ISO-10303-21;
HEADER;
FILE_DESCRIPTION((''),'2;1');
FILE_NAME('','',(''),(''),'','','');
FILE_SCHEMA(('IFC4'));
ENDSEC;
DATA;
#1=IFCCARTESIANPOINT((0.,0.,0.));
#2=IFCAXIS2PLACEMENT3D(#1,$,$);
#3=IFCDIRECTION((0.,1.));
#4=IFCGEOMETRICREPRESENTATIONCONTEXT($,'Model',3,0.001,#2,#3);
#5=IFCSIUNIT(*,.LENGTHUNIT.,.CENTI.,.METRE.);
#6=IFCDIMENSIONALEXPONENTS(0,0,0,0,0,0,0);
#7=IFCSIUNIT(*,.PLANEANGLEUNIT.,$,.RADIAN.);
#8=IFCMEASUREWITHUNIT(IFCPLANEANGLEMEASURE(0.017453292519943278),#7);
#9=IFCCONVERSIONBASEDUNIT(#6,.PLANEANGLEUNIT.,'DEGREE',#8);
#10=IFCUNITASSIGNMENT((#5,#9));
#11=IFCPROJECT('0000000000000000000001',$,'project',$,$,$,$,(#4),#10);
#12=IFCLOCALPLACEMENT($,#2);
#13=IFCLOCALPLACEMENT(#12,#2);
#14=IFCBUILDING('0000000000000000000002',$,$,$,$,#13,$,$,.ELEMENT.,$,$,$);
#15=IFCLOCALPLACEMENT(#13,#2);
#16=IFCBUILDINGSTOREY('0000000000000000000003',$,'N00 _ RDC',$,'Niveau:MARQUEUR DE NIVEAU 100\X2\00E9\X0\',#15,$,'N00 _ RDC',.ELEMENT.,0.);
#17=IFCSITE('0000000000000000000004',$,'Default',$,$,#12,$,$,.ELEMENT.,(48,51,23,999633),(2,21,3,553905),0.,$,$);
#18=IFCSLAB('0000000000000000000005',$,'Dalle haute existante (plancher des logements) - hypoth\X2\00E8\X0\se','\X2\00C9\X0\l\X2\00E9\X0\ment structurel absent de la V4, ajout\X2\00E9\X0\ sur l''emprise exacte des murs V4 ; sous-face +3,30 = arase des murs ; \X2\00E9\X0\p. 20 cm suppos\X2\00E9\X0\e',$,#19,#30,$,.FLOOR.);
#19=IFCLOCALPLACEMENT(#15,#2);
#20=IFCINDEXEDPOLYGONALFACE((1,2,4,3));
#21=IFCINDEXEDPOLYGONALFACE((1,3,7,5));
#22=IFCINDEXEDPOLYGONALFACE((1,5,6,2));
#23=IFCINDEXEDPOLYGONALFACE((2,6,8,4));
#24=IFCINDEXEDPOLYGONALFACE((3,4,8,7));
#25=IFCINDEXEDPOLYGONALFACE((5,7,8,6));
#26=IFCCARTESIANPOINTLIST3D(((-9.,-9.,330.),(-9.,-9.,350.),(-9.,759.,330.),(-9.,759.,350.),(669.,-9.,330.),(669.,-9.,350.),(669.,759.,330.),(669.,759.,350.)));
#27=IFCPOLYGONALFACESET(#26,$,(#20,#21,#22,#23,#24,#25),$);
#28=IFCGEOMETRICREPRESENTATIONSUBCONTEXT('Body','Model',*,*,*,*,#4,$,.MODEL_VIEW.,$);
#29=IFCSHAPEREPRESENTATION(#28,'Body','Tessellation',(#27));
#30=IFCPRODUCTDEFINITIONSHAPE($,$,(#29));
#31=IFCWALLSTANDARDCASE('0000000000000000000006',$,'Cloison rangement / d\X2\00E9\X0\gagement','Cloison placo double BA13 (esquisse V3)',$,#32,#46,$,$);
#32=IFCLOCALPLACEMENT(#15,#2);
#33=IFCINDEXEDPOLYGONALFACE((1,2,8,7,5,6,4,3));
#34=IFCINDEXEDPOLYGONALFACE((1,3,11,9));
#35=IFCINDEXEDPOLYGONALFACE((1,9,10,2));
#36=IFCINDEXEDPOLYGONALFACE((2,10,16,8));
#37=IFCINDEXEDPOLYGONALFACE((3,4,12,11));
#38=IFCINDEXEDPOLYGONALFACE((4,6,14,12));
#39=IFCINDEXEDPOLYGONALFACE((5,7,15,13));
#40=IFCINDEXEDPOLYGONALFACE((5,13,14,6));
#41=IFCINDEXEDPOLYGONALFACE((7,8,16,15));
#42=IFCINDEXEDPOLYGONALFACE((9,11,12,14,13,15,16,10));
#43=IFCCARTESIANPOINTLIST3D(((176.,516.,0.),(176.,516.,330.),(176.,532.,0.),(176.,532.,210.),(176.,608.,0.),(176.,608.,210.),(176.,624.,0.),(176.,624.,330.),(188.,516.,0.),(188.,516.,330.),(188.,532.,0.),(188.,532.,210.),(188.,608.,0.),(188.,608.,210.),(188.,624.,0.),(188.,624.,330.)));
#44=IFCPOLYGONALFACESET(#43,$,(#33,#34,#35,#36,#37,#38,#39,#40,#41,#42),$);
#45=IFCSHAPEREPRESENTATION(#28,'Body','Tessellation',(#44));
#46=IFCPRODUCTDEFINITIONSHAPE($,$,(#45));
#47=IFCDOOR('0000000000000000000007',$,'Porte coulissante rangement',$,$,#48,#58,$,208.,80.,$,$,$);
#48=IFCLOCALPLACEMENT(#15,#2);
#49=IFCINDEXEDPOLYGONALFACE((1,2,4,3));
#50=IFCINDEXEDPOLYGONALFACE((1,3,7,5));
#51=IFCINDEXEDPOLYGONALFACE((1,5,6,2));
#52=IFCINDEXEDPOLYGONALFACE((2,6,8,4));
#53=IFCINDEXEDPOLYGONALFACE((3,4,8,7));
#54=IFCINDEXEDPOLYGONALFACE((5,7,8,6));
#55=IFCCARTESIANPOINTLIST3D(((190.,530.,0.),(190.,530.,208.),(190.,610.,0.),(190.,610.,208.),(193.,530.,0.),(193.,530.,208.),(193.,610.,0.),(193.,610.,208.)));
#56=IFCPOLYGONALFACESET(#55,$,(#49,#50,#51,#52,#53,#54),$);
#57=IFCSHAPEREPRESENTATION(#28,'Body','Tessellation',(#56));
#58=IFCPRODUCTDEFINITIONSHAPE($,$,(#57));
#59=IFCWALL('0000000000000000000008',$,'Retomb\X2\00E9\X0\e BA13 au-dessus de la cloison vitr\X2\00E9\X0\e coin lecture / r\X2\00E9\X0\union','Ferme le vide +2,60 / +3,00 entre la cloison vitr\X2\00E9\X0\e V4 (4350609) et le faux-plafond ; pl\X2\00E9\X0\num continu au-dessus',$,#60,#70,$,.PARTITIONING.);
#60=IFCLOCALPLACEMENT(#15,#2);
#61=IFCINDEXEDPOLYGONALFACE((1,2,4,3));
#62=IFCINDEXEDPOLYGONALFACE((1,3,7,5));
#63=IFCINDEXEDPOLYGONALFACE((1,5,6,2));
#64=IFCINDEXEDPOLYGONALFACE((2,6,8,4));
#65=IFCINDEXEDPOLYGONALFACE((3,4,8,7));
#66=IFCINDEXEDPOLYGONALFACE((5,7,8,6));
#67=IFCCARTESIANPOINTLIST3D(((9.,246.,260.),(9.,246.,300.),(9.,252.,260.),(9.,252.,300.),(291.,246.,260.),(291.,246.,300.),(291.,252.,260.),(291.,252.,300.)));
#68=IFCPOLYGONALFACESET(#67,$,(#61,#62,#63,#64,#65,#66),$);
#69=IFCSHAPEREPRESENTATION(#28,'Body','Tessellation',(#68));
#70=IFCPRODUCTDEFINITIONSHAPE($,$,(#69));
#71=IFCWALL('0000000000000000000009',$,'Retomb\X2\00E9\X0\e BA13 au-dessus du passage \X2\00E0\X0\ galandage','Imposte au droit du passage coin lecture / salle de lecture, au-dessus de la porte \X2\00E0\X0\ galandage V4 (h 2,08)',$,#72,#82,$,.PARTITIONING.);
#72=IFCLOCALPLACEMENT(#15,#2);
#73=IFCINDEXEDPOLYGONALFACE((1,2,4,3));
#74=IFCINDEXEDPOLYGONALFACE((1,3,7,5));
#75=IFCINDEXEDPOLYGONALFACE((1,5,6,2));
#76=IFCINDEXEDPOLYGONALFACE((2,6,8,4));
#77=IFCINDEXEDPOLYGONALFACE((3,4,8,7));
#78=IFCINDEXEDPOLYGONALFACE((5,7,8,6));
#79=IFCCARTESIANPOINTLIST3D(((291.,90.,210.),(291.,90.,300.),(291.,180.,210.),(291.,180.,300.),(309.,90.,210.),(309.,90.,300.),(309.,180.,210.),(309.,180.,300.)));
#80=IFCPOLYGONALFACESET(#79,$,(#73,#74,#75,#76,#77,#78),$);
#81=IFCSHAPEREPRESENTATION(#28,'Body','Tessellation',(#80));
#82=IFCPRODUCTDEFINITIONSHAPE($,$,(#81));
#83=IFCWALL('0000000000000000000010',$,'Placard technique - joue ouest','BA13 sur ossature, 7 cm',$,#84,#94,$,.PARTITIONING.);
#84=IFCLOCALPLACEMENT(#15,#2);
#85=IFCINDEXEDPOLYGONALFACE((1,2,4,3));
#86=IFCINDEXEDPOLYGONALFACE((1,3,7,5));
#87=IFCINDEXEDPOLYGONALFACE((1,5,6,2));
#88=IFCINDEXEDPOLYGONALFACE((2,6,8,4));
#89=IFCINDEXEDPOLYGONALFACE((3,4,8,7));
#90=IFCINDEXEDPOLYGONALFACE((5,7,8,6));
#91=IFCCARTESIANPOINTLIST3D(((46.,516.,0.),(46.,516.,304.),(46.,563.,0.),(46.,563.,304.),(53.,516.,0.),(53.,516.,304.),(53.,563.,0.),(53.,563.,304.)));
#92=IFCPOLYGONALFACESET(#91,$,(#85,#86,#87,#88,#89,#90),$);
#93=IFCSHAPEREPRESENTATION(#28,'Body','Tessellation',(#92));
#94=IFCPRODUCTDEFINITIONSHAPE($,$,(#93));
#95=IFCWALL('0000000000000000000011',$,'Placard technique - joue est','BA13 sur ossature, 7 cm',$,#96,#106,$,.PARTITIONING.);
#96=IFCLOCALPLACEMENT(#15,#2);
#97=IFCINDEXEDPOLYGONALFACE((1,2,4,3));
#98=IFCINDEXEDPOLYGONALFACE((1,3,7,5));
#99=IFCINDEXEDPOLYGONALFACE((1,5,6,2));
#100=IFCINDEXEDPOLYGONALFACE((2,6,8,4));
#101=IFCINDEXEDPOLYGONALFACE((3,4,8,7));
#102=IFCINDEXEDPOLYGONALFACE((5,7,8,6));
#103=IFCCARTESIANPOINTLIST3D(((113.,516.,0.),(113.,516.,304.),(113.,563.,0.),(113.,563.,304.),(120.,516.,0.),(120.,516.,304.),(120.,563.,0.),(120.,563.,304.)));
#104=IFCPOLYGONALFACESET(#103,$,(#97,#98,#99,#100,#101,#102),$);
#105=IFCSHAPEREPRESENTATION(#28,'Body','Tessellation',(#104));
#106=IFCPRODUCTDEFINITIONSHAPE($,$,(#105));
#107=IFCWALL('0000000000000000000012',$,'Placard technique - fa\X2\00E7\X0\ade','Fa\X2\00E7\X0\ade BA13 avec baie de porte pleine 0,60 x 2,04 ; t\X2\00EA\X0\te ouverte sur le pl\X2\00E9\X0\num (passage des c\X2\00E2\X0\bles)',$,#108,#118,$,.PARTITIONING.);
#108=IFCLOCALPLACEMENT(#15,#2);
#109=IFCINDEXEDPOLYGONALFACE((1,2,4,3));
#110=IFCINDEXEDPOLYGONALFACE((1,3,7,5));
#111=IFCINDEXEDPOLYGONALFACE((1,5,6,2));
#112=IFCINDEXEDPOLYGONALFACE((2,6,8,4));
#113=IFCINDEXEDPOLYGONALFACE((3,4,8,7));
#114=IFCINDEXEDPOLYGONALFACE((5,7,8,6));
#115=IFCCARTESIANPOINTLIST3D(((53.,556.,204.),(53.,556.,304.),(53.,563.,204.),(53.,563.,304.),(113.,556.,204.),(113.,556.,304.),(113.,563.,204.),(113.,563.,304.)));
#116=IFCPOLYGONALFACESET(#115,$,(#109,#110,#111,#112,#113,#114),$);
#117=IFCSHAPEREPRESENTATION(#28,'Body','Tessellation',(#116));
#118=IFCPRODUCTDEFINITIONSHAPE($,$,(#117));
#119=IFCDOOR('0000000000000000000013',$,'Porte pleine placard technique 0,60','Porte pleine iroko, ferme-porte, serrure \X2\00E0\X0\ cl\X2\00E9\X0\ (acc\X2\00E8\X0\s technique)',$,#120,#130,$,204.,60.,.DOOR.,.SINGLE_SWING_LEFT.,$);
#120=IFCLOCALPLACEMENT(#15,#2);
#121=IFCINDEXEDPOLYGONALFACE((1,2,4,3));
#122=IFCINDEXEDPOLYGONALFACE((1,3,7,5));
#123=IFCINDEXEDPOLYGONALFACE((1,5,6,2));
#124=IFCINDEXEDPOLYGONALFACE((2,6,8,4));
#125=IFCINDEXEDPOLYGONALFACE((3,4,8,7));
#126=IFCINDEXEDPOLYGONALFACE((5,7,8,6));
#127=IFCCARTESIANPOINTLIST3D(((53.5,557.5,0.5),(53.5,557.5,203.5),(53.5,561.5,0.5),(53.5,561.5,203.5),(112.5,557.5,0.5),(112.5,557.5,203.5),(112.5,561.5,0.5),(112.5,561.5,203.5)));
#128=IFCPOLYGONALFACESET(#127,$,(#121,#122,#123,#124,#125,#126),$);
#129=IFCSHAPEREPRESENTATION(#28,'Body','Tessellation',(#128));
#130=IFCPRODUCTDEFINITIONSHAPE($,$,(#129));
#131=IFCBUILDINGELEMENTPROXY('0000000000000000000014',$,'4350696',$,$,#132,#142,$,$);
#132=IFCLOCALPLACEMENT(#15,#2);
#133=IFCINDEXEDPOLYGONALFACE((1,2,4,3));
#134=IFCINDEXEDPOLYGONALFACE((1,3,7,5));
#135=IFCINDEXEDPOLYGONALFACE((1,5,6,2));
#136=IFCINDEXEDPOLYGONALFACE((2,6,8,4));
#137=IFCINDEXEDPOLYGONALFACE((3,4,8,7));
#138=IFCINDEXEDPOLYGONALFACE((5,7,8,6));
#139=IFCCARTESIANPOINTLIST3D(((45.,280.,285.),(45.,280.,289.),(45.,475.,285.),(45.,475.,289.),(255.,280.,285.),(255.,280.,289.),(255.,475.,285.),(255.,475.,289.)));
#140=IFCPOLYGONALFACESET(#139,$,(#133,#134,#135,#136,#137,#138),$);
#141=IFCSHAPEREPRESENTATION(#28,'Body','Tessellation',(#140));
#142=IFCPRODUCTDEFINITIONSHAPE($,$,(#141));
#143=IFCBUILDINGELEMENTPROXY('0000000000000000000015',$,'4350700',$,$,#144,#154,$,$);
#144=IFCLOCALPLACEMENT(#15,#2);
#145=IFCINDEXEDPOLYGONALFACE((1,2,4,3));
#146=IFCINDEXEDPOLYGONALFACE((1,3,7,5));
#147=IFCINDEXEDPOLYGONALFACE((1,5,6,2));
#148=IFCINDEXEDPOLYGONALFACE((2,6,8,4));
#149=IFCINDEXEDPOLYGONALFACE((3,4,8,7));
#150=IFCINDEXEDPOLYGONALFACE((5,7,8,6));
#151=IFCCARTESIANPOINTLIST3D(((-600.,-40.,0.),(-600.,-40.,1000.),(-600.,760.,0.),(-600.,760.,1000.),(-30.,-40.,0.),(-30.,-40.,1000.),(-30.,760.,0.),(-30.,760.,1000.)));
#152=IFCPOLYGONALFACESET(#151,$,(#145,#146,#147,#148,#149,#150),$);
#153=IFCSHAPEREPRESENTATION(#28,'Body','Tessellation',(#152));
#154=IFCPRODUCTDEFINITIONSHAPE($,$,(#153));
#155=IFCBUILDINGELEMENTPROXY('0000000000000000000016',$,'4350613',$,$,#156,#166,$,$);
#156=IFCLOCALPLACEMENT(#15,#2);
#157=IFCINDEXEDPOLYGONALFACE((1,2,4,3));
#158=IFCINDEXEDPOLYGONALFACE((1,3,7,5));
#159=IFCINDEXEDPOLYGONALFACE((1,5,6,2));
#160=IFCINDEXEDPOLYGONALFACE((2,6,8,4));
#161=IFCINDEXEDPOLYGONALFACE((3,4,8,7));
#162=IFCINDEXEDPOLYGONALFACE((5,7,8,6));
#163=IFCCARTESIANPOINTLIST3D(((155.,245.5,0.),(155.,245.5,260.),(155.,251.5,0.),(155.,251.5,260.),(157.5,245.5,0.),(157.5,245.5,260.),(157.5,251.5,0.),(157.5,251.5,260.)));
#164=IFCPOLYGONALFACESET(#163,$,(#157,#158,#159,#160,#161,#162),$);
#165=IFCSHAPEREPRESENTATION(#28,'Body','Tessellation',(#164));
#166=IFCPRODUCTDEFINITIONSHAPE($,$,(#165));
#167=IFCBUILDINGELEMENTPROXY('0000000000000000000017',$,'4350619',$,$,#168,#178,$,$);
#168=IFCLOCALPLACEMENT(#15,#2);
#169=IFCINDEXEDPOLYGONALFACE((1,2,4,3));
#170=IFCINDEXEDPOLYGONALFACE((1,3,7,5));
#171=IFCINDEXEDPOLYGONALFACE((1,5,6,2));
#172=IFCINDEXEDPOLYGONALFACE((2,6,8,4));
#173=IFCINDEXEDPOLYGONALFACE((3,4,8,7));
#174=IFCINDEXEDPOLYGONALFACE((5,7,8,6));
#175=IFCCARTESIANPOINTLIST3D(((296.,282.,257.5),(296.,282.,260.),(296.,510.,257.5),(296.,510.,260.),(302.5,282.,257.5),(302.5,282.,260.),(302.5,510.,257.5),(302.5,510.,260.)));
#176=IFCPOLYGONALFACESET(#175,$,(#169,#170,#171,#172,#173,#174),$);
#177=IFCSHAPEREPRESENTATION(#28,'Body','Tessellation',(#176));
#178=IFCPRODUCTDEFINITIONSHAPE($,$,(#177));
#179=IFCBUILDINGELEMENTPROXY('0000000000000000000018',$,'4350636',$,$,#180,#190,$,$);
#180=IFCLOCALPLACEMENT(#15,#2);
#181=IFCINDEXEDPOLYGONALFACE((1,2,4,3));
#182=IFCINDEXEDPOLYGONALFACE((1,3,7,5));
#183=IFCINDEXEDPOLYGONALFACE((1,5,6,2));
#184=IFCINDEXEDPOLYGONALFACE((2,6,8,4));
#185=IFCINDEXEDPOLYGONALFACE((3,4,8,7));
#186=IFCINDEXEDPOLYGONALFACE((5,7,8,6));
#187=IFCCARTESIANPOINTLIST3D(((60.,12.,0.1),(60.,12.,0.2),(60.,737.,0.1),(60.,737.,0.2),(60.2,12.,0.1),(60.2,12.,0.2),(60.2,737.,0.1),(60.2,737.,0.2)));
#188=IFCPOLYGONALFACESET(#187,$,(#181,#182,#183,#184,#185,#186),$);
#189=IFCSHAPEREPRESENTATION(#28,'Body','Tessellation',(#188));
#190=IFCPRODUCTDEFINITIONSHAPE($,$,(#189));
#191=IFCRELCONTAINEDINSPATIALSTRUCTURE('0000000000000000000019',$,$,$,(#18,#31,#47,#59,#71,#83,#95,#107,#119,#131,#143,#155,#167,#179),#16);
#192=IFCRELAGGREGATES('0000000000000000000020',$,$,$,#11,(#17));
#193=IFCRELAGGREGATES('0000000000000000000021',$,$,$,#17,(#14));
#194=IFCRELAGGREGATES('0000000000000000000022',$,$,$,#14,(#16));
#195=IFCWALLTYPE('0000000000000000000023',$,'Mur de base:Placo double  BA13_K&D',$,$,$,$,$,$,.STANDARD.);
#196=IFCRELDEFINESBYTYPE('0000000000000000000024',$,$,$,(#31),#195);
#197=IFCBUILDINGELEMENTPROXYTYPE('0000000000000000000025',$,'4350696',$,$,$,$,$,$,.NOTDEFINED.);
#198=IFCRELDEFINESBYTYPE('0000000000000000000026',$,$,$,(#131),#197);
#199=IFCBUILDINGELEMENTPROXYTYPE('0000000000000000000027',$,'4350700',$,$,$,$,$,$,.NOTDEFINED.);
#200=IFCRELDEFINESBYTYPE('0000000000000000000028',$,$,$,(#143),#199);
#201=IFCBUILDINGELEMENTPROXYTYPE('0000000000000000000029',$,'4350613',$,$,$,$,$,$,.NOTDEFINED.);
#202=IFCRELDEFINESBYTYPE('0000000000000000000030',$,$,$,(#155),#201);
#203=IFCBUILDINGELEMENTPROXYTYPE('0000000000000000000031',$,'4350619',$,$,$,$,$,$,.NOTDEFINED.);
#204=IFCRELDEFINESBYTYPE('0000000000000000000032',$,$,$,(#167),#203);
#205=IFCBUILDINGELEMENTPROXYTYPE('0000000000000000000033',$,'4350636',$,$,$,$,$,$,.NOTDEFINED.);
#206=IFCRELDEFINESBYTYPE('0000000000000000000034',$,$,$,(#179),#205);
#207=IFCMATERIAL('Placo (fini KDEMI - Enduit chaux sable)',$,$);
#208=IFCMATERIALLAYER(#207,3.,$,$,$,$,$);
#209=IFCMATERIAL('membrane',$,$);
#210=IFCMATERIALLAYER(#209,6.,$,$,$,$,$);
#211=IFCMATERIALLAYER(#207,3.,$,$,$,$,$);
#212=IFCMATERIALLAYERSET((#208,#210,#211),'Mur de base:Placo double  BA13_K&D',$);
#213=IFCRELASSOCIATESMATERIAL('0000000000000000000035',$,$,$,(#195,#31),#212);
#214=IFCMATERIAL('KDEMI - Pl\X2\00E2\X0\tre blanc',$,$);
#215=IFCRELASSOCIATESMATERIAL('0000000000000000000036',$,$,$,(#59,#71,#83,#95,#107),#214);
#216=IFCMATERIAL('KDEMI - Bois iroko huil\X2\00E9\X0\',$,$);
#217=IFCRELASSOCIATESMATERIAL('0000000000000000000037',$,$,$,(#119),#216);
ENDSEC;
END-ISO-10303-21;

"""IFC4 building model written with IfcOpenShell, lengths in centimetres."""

from ifc_helpers import new_model, entity, si_unit, converted_unit, direction, frame, frame_2d, origin, origin_with_axes, origin_2d_with_axis, place, context, subcontext, project, spatial, polyline, rectangle, outline, extrude, material, layer, layer_set, layer_usage, type_object, element, fill, save


model = new_model("IFC4")

# Units and contexts
model_context = context("Model", 3, precision=0.001, world=origin(), true_north=direction((0.0, 1.0)))
body_context = subcontext(model_context, "Body", "Model", "MODEL_VIEW")
ifc_project = project(units=[si_unit("LENGTHUNIT", "METRE", prefix="CENTI"), converted_unit("PLANEANGLEUNIT", "DEGREE", entity("IfcPlaneAngleMeasure", 0.017453292519943278), si_unit("PLANEANGLEUNIT", "RADIAN"), dimensions=[0, 0, 0, 0, 0, 0, 0])], contexts=[model_context])

# Site, building, storey
site_placement = place(None, origin())
site = spatial("IfcSite", under=ifc_project, at=site_placement, Name="Default", CompositionType="ELEMENT", RefLatitude=(48, 51, 23, 999633), RefLongitude=(2, 21, 3, 553905), RefElevation=0.0)
building_placement = place(site_placement, origin())
building = spatial("IfcBuilding", under=site, at=building_placement, CompositionType="ELEMENT")
storey_placement = place(building_placement, origin())
storey = spatial("IfcBuildingStorey", under=building, at=storey_placement, Name="N00 _ RDC", ObjectType="Niveau:MARQUEUR DE NIVEAU 100é", LongName="N00 _ RDC", CompositionType="ELEMENT", Elevation=0.0)

# Slab
slab_placement = place(storey_placement, origin_with_axes())
element("IfcSlab", 1, at=slab_placement, inside=storey, Name="Dalle haute existante (plancher des logements) - hypothèse", Description="Élément structurel absent de la V4, ajouté sur l'emprise exacte des murs V4 ; sous-face +3,30 = arase des murs ; ép. 20 cm supposée", PredefinedType="FLOOR", context=body_context, shape_type="SweptSolid", body=[
    extrude(outline(polyline([(669.0, -9.0), (-9.0, -9.0), (-9.0, 759.0), (669.0, 759.0), (669.0, -9.0)])), frame((0.0, 0.0, 330.0)), (0.0, 0.0, 1.0), 20.0),
])

# Wall, opening, door
ifc_material_1 = material(Name="Placo (fini KDEMI - Enduit chaux sable)")
ifc_layer_1 = layer(ifc_material_1, 3.0)
ifc_material_2 = material(Name="membrane")
ifc_layer_2 = layer(ifc_material_2, 6.0)
ifc_layer_3 = layer(ifc_material_1, 3.0)
ifc_layer_set = layer_set([ifc_layer_1, ifc_layer_2, ifc_layer_3], Name="Mur de base:Placo double  BA13_K&D")
ifc_layer_usage = layer_usage(ifc_layer_set, "AXIS2", "POSITIVE", 0.0)
wall_type = type_object("IfcWallType", Name="Mur de base:Placo double  BA13_K&D", PredefinedType="STANDARD", material=ifc_layer_set)
wall_1_placement = place(storey_placement, origin_with_axes())
wall_1 = element("IfcWallStandardCase", 2, at=wall_1_placement, inside=storey, type_object=wall_type, material=ifc_layer_usage, Name="Cloison rangement / dégagement", Description="Cloison placo double BA13 (esquisse V3)", context=body_context, shape_type="SweptSolid", body=[
    extrude(rectangle(XDim=12.0, YDim=108.0, at=frame_2d((182.0, 570.0))), origin(), (0.0, 0.0, 1.0), 330.0),
])
opening_1_placement = place(wall_1_placement, origin_with_axes())
opening_1 = element("IfcOpeningElement", 3, at=opening_1_placement, inside=storey, cuts=wall_1, context=body_context, shape_type="SweptSolid", body=[
    extrude(rectangle(XDim=16.0, YDim=76.0, at=frame_2d((182.0, 570.0))), origin(), (0.0, 0.0, 1.0), 210.0),
])
door_1_placement = place(storey_placement, origin_with_axes())
door_1 = element("IfcDoor", 4, at=door_1_placement, inside=storey, Name="Porte coulissante rangement", OverallHeight=208.0, OverallWidth=80.0, context=body_context, shape_type="SweptSolid", body=[
    extrude(rectangle(XDim=3.0, YDim=80.0, at=frame_2d((191.5, 570.0))), origin(), (0.0, 0.0, 1.0), 208.0),
])
fill(opening_1, door_1)

# Walls
ifc_material_3 = material(Name="KDEMI - Plâtre blanc")
wall_2_placement = place(storey_placement, origin_with_axes())
element("IfcWall", 5, at=wall_2_placement, inside=storey, material=ifc_material_3, Name="Retombée BA13 au-dessus de la cloison vitrée coin lecture / réunion", Description="Ferme le vide +2,60 / +3,00 entre la cloison vitrée V4 (4350609) et le faux-plafond ; plénum continu au-dessus", PredefinedType="PARTITIONING", context=body_context, shape_type="SweptSolid", body=[
    extrude(rectangle(XDim=282.0, YDim=6.0, at=frame_2d((150.0, 249.0))), frame((0.0, 0.0, 260.0)), (0.0, 0.0, 1.0), 40.0),
])
wall_3_placement = place(storey_placement, origin_with_axes())
element("IfcWall", 6, at=wall_3_placement, inside=storey, material=ifc_material_3, Name="Retombée BA13 au-dessus du passage à galandage", Description="Imposte au droit du passage coin lecture / salle de lecture, au-dessus de la porte à galandage V4 (h 2,08)", PredefinedType="PARTITIONING", context=body_context, shape_type="SweptSolid", body=[
    extrude(rectangle(XDim=18.0, YDim=90.0, at=frame_2d((300.0, 135.0))), frame((0.0, 0.0, 210.0)), (0.0, 0.0, 1.0), 90.0),
])
wall_4_placement = place(storey_placement, origin_with_axes())
element("IfcWall", 7, at=wall_4_placement, inside=storey, material=ifc_material_3, Name="Placard technique - joue ouest", Description="BA13 sur ossature, 7 cm", PredefinedType="PARTITIONING", context=body_context, shape_type="SweptSolid", body=[
    extrude(rectangle(XDim=7.0, YDim=47.0, at=frame_2d((49.5, 539.5))), origin(), (0.0, 0.0, 1.0), 304.0),
])
wall_5_placement = place(storey_placement, origin_with_axes())
element("IfcWall", 8, at=wall_5_placement, inside=storey, material=ifc_material_3, Name="Placard technique - joue est", Description="BA13 sur ossature, 7 cm", PredefinedType="PARTITIONING", context=body_context, shape_type="SweptSolid", body=[
    extrude(rectangle(XDim=7.0, YDim=47.0, at=frame_2d((116.5, 539.5))), origin(), (0.0, 0.0, 1.0), 304.0),
])

# Wall, opening, door
wall_6_placement = place(storey_placement, origin_with_axes())
wall_6 = element("IfcWall", 9, at=wall_6_placement, inside=storey, material=ifc_material_3, Name="Placard technique - façade", Description="Façade BA13 avec baie de porte pleine 0,60 x 2,04 ; tête ouverte sur le plénum (passage des câbles)", PredefinedType="PARTITIONING", context=body_context, shape_type="SweptSolid", body=[
    extrude(rectangle(XDim=60.0, YDim=7.0, at=frame_2d((83.0, 559.5))), origin(), (0.0, 0.0, 1.0), 304.0),
])
opening_2_placement = place(wall_6_placement, origin_with_axes())
opening_2 = element("IfcOpeningElement", 10, at=opening_2_placement, cuts=wall_6, PredefinedType="OPENING", context=body_context, shape_type="SweptSolid", body=[
    extrude(rectangle(XDim=60.0, YDim=9.0, at=frame_2d((83.0, 559.5))), origin(), (0.0, 0.0, 1.0), 204.0),
])
ifc_material_4 = material(Name="KDEMI - Bois iroko huilé")
door_2_placement = place(storey_placement, origin_with_axes())
door_2 = element("IfcDoor", 11, at=door_2_placement, inside=storey, material=ifc_material_4, Name="Porte pleine placard technique 0,60", Description="Porte pleine iroko, ferme-porte, serrure à clé (accès technique)", OperationType="SINGLE_SWING_LEFT", OverallHeight=204.0, OverallWidth=60.0, PredefinedType="DOOR", context=body_context, shape_type="SweptSolid", body=[
    extrude(rectangle(XDim=59.0, YDim=4.0, at=frame_2d((83.0, 559.5))), frame((0.0, 0.0, 0.5)), (0.0, 0.0, 1.0), 203.0),
])
fill(opening_2, door_2)

# Building element proxies
building_element_proxy_type_1 = type_object("IfcBuildingElementProxyType", Name="4350696", PredefinedType="NOTDEFINED")
proxy_1_placement = place(storey_placement, origin())
element("IfcBuildingElementProxy", 12, at=proxy_1_placement, inside=storey, type_object=building_element_proxy_type_1, Name="4350696", context=body_context, shape_type="SweptSolid", body=[
    extrude(rectangle(XDim=210.0, YDim=195.0, at=frame_2d((0.0, 0.0), x_axis=(1.0, 0.0))), frame((150.0, 377.5, 285.0)), (0.0, 0.0, 1.0), 4.0),
])
building_element_proxy_type_2 = type_object("IfcBuildingElementProxyType", Name="4350700", PredefinedType="NOTDEFINED")
proxy_2_placement = place(storey_placement, origin())
element("IfcBuildingElementProxy", 13, at=proxy_2_placement, inside=storey, type_object=building_element_proxy_type_2, Name="4350700", context=body_context, shape_type="SweptSolid", body=[
    extrude(rectangle(XDim=570.0, YDim=800.0, at=origin_2d_with_axis()), frame((-315.0, 360.0, 0.0)), (0.0, 0.0, 1.0), 1000.0),
])
building_element_proxy_type_3 = type_object("IfcBuildingElementProxyType", Name="4350613", PredefinedType="NOTDEFINED")
proxy_3_placement = place(storey_placement, origin())
element("IfcBuildingElementProxy", 14, at=proxy_3_placement, inside=storey, type_object=building_element_proxy_type_3, Name="4350613", context=body_context, shape_type="SweptSolid", body=[
    extrude(rectangle(XDim=2.5, YDim=6.0, at=frame_2d((0.0, 0.0), x_axis=(1.0, 0.0))), frame((156.25, 248.5, 0.0)), (0.0, 0.0, 1.0), 260.0),
])
building_element_proxy_type_4 = type_object("IfcBuildingElementProxyType", Name="4350619", PredefinedType="NOTDEFINED")
proxy_4_placement = place(storey_placement, origin())
element("IfcBuildingElementProxy", 15, at=proxy_4_placement, inside=storey, type_object=building_element_proxy_type_4, Name="4350619", context=body_context, shape_type="SweptSolid", body=[
    extrude(rectangle(XDim=6.5, YDim=228.0, at=frame_2d((0.0, 0.0), x_axis=(1.0, 0.0))), frame((299.25, 396.0, 257.5)), (0.0, 0.0, 1.0), 2.5),
])
building_element_proxy_type_5 = type_object("IfcBuildingElementProxyType", Name="4350636", PredefinedType="NOTDEFINED")
proxy_5_placement = place(storey_placement, origin())
element("IfcBuildingElementProxy", 16, at=proxy_5_placement, inside=storey, type_object=building_element_proxy_type_5, Name="4350636", context=body_context, shape_type="SweptSolid", body=[
    extrude(rectangle(XDim=0.2, YDim=725.0, at=frame_2d((0.0, 0.0), x_axis=(1.0, 0.0))), frame((60.1, 374.5, 0.1)), (0.0, 0.0, 1.0), 0.1),
])

save(model, "model.ifc")
